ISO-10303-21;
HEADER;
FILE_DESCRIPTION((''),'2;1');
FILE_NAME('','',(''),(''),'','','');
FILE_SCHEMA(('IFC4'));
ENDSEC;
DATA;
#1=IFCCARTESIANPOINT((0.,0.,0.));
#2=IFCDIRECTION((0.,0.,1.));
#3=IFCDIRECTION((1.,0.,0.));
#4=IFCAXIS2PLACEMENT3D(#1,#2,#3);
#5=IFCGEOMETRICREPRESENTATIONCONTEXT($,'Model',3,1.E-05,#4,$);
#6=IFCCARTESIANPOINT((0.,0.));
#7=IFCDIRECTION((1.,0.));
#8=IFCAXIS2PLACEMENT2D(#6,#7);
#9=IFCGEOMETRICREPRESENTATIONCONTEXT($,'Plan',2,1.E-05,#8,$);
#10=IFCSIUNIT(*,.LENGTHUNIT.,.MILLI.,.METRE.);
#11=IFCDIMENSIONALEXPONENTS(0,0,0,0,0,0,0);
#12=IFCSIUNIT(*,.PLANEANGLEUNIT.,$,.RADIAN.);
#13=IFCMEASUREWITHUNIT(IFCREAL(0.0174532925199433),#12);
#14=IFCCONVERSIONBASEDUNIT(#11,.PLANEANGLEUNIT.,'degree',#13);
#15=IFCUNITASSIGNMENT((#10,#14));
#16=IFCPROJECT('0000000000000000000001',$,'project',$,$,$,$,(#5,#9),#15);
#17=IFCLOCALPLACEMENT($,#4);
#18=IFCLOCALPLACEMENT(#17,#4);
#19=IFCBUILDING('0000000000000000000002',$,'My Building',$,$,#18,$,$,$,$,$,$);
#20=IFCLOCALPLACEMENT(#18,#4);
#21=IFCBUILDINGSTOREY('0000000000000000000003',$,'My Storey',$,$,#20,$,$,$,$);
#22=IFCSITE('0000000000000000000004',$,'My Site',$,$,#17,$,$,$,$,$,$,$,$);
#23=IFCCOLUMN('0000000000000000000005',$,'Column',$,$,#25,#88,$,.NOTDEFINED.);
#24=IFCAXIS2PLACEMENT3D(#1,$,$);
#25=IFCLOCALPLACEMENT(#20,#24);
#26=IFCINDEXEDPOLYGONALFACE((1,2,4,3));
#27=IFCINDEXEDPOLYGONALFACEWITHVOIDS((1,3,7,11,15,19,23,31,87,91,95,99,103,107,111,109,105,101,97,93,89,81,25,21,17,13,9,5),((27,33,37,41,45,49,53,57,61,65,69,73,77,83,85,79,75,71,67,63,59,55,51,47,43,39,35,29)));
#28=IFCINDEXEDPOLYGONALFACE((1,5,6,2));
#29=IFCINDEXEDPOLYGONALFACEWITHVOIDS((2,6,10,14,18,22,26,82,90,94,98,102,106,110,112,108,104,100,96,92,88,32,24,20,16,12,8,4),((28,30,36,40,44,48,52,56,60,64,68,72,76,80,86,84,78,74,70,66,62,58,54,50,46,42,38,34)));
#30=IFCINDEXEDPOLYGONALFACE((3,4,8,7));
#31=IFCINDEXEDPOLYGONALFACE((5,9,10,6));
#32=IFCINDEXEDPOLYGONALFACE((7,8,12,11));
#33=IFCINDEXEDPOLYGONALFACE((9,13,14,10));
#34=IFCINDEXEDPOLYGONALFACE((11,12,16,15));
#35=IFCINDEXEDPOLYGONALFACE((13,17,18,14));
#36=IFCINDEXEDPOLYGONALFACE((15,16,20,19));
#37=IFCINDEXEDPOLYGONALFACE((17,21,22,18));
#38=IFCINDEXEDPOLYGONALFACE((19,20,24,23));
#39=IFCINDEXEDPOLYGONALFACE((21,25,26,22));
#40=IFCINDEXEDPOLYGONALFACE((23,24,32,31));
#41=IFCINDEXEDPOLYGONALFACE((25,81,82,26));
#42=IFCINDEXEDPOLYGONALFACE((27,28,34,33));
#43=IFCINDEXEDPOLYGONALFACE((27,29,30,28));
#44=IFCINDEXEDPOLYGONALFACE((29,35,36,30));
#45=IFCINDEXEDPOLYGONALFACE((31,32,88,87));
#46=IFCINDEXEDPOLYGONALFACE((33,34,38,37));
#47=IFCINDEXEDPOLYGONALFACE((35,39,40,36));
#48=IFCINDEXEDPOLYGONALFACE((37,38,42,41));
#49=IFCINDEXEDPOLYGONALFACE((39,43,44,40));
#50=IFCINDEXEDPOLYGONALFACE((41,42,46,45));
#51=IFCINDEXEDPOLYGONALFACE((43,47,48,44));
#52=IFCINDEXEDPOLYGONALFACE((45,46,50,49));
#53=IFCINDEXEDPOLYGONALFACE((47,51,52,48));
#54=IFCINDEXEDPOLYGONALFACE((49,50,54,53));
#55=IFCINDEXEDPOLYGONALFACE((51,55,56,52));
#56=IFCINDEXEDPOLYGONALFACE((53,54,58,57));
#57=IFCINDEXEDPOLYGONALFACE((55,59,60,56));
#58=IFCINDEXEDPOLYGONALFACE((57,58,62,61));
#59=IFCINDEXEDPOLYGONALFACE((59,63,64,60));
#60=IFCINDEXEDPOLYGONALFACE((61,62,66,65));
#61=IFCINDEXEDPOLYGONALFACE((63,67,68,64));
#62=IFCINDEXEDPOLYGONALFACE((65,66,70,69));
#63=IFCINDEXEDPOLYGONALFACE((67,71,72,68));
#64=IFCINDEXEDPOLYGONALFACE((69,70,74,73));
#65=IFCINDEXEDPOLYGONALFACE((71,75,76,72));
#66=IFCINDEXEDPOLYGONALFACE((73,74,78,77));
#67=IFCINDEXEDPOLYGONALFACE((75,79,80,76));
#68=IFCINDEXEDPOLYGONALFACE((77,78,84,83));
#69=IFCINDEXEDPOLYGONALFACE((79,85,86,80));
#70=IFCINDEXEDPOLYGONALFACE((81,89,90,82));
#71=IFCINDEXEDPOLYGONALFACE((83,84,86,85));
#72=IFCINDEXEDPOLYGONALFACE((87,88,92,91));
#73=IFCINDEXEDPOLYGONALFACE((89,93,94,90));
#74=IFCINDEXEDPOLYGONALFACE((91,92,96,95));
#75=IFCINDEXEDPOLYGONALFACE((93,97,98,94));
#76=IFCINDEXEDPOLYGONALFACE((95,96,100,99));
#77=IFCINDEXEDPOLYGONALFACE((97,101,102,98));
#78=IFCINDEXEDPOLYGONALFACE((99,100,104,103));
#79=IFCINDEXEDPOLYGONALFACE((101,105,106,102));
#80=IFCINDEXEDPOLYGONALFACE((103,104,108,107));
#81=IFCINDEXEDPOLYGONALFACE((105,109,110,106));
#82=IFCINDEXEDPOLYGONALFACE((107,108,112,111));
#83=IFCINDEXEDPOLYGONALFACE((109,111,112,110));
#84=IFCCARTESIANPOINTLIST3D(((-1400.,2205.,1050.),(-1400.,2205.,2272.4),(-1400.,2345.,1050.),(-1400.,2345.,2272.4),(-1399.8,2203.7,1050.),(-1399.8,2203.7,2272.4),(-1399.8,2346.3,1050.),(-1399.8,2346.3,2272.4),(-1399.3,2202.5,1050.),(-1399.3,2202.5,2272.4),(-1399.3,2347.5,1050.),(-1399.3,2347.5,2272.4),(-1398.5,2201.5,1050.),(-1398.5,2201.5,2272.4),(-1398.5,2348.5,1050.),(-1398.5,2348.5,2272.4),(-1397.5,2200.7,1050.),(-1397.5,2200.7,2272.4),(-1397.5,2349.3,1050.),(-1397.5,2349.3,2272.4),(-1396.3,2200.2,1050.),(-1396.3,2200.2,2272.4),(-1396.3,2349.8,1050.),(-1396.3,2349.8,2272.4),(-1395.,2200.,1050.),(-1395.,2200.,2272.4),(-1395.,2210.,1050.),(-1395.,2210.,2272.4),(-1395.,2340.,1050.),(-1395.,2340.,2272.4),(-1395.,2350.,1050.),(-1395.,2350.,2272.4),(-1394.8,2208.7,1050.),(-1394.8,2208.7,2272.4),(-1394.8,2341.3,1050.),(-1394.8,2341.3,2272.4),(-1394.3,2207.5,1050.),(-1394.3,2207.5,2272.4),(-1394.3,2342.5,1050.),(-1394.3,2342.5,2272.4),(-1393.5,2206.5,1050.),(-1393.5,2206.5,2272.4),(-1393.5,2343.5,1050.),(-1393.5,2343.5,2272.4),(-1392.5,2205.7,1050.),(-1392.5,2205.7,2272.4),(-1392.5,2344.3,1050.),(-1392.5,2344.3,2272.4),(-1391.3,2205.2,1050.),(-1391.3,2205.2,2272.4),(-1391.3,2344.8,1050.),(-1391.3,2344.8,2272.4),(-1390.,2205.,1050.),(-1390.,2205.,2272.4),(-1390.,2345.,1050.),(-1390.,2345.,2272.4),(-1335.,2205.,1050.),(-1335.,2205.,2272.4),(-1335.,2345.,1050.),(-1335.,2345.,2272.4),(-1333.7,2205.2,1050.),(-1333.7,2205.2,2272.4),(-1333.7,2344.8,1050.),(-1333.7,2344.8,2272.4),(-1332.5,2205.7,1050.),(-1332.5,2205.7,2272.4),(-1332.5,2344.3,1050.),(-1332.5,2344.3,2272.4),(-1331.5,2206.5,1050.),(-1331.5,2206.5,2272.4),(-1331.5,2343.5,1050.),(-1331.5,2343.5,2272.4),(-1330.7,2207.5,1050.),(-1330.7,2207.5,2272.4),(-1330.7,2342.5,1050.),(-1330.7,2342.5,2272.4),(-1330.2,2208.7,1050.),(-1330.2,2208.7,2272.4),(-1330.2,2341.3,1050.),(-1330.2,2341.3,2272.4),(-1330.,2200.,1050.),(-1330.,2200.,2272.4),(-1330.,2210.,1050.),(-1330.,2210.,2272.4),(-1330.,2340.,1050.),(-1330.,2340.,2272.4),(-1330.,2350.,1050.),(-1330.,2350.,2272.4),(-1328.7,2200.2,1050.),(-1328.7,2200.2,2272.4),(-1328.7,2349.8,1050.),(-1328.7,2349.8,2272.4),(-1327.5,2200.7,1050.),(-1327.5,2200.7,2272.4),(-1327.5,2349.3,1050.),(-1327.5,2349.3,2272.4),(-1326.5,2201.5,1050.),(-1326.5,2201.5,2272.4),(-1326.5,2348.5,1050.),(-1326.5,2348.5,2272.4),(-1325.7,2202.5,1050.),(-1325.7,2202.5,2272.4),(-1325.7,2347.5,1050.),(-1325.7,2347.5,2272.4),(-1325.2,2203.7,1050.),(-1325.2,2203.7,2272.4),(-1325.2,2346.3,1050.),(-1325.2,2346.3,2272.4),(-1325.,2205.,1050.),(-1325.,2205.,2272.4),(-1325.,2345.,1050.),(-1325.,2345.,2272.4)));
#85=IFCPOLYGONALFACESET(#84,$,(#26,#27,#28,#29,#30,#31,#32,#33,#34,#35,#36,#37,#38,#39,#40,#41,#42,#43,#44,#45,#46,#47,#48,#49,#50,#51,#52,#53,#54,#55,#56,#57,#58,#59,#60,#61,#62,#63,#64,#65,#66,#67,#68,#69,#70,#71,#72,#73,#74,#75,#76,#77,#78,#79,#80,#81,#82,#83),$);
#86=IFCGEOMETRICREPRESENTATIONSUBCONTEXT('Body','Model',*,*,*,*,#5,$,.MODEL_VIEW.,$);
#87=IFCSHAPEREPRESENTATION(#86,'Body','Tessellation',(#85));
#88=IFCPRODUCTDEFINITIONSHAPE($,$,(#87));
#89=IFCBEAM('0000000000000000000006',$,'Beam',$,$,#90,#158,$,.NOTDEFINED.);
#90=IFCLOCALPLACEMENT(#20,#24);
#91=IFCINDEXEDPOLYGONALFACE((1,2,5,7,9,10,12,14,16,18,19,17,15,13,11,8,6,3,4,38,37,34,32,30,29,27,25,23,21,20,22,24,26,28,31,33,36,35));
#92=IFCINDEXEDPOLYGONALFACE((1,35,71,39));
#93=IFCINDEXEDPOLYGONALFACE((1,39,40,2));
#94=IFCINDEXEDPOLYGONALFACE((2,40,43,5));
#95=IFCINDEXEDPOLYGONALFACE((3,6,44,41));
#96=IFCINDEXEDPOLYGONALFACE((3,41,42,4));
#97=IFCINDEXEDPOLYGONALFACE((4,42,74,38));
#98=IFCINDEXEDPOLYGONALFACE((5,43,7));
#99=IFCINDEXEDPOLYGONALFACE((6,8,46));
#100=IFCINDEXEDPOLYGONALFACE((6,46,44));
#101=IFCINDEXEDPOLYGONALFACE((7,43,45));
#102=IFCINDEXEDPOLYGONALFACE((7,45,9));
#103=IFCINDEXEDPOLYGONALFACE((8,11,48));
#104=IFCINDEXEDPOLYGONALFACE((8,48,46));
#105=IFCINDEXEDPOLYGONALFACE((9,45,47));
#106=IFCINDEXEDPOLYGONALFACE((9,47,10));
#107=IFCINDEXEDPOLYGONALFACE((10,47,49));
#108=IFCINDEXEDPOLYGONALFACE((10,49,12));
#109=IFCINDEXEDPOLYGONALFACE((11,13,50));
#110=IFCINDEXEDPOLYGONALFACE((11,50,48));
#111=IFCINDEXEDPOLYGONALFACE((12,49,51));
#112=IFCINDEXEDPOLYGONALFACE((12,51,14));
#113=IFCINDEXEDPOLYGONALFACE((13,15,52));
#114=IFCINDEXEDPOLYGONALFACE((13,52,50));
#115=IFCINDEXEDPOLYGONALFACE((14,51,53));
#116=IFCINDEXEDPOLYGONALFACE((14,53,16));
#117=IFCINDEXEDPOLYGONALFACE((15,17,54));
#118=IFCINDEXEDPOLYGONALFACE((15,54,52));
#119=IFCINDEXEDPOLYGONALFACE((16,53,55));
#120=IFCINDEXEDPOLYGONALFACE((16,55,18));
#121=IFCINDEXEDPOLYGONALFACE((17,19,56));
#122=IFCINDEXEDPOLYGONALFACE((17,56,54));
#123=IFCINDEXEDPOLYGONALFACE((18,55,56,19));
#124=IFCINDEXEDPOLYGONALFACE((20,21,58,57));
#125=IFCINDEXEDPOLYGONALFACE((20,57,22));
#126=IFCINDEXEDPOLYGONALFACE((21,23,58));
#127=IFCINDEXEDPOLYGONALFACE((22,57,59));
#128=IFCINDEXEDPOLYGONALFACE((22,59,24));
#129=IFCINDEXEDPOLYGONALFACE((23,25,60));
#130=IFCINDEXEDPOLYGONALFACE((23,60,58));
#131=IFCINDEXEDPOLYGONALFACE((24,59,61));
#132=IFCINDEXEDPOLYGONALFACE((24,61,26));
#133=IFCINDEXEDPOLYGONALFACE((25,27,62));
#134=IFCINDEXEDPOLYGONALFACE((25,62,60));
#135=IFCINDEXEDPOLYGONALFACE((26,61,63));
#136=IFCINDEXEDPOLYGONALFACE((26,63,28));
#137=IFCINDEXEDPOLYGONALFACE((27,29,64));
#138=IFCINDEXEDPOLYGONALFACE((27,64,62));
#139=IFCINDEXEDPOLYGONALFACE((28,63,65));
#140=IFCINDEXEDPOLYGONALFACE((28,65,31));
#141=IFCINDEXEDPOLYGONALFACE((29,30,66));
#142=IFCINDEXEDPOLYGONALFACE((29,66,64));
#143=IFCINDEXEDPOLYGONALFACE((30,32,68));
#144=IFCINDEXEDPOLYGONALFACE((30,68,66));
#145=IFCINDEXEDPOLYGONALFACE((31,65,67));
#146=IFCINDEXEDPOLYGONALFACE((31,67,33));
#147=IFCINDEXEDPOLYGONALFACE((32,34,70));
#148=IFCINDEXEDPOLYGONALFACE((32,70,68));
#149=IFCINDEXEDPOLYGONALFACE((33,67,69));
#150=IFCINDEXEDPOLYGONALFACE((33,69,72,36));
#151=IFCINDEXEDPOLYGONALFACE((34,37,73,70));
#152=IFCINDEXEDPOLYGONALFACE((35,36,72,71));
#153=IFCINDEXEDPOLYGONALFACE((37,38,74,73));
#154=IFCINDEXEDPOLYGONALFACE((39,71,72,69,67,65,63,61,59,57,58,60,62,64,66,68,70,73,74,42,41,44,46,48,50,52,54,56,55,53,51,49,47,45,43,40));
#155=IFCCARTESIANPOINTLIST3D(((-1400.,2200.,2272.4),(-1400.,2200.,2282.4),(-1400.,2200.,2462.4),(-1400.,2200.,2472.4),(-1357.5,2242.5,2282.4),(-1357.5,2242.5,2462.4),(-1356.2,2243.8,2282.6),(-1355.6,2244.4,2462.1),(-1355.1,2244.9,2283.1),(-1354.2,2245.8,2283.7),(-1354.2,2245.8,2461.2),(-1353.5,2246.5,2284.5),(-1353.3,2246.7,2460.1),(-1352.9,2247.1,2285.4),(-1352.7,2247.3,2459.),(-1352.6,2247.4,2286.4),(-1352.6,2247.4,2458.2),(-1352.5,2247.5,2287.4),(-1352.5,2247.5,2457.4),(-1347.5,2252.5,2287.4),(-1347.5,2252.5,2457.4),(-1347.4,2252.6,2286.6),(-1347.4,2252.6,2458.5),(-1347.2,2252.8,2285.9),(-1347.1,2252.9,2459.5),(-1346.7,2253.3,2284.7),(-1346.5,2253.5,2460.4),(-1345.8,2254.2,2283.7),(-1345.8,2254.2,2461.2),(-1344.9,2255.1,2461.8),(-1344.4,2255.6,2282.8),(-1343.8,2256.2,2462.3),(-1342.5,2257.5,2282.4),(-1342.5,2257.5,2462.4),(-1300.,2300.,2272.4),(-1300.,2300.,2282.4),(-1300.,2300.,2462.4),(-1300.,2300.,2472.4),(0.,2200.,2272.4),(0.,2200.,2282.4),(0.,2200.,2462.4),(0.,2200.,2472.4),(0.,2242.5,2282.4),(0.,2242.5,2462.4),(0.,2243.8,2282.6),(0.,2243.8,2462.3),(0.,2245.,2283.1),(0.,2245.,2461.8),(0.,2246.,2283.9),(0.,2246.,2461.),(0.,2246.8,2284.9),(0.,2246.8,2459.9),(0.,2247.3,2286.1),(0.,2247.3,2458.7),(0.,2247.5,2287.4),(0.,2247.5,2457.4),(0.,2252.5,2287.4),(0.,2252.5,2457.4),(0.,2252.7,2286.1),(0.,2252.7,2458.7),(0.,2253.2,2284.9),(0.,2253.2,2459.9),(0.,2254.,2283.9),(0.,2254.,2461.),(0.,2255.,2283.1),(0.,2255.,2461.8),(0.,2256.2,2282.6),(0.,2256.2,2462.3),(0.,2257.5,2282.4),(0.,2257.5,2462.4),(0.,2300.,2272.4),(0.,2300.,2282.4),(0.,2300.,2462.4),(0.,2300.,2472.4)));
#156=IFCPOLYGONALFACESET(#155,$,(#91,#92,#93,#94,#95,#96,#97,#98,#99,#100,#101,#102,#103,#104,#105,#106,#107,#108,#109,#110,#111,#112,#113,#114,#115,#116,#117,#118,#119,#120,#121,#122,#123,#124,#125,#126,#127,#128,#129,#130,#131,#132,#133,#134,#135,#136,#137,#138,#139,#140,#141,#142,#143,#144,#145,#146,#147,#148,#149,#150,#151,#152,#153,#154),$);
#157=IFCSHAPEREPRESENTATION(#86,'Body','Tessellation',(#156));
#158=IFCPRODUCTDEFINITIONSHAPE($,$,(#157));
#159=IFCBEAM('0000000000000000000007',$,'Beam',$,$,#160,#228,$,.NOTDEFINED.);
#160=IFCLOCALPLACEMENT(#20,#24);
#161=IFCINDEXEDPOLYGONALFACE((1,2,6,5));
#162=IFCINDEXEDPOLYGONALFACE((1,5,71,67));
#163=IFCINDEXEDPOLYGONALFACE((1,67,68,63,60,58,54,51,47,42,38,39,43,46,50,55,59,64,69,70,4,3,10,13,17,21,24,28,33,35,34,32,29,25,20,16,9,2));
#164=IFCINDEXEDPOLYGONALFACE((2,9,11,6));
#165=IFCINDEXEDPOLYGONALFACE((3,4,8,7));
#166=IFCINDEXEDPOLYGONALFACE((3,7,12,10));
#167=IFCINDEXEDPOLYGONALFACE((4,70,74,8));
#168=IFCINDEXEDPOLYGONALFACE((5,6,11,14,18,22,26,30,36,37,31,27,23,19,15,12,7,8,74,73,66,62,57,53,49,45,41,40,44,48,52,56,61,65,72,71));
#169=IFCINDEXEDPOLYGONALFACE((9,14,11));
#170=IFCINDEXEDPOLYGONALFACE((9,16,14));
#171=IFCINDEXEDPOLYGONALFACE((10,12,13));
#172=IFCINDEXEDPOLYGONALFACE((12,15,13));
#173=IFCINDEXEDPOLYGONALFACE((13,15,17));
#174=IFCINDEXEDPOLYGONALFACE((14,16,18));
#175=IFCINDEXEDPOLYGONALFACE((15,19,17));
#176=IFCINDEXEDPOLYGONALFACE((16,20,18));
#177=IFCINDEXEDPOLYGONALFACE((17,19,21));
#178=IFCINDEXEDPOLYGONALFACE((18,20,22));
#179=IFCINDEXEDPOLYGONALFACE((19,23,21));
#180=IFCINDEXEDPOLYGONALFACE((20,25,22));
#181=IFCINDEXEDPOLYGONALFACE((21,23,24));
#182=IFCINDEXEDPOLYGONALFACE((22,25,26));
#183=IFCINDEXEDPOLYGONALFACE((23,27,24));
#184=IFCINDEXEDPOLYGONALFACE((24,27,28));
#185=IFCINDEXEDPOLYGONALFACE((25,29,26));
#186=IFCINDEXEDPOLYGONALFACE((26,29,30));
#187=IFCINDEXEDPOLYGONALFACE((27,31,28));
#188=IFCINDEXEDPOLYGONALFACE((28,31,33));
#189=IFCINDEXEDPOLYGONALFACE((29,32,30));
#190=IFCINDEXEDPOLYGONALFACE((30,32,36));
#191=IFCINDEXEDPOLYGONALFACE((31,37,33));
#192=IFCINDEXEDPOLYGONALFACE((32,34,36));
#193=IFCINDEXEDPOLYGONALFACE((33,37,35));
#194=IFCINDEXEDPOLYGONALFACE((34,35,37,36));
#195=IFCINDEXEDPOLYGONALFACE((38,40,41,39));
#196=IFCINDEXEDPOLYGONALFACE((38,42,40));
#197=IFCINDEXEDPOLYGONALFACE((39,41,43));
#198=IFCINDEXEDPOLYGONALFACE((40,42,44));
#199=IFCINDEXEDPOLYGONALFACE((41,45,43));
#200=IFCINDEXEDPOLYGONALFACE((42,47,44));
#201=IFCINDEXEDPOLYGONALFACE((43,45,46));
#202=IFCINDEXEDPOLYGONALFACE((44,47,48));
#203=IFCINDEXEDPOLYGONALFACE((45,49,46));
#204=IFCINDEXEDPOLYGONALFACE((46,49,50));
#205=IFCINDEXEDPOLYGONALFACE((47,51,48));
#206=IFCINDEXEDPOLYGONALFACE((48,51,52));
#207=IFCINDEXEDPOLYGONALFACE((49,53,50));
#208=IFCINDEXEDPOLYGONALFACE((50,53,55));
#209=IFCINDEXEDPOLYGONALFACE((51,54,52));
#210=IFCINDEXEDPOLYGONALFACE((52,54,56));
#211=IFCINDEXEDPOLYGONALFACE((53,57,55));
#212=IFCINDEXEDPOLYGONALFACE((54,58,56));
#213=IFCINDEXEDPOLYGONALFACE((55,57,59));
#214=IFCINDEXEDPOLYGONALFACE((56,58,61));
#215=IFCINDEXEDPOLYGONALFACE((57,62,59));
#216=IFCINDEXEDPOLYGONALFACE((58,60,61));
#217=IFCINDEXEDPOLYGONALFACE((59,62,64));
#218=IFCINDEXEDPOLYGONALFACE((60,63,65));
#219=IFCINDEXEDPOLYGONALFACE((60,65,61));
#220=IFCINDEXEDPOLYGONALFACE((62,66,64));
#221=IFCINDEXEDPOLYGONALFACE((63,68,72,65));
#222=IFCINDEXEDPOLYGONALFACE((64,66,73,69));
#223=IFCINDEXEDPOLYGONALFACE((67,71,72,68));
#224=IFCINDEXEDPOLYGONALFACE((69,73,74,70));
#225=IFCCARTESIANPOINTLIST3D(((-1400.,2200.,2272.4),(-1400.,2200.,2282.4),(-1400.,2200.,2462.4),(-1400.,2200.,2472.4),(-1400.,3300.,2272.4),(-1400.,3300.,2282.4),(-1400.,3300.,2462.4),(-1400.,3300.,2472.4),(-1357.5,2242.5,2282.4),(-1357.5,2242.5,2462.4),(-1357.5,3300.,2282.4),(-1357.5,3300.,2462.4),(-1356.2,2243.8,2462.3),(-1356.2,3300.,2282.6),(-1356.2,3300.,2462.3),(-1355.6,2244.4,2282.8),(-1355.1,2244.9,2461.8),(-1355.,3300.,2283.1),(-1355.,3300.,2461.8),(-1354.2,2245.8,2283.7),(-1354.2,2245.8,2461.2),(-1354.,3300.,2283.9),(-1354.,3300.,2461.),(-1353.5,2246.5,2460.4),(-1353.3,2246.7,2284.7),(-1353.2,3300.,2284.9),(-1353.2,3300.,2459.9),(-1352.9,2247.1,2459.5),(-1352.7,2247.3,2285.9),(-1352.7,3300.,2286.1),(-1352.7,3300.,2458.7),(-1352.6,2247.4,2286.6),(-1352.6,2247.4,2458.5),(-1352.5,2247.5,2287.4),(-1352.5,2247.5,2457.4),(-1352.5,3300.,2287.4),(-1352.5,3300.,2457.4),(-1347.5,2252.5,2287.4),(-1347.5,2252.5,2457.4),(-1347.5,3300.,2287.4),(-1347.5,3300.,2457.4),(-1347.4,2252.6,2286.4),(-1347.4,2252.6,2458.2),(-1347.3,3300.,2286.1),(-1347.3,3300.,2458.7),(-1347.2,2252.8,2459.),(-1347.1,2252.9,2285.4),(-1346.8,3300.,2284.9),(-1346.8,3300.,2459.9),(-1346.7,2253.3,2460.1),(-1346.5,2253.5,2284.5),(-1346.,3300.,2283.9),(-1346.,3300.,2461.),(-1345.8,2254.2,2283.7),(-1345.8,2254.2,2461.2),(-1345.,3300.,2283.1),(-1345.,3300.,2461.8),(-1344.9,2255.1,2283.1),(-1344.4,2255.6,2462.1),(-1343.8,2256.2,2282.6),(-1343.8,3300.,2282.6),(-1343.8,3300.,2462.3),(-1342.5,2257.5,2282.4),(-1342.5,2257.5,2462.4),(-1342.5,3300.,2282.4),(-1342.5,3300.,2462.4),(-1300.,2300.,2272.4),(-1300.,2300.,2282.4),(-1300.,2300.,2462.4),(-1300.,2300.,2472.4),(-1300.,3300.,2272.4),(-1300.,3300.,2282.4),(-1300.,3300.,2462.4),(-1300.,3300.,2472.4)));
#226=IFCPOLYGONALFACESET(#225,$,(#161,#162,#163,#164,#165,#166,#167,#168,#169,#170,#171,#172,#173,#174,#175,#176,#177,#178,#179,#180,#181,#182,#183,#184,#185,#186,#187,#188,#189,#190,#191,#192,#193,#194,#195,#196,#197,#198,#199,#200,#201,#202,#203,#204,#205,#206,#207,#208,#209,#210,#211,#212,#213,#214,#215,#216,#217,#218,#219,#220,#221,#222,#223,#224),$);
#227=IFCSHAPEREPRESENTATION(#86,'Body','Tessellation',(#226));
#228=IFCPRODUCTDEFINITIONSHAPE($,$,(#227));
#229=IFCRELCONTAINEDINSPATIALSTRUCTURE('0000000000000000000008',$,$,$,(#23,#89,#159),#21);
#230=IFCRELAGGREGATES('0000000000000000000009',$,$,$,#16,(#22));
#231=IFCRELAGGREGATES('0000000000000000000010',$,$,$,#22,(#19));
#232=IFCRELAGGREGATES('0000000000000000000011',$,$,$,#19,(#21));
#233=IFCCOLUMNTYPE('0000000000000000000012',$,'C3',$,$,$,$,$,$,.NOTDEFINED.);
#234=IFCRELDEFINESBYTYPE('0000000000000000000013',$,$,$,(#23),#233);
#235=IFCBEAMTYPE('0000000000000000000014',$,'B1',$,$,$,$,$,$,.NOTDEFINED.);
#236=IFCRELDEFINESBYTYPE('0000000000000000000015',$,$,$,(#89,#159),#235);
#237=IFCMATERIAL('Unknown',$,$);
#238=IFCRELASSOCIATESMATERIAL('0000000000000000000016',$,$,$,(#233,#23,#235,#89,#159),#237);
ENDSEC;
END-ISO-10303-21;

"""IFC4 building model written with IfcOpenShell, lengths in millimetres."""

from ifc_helpers import new_model, entity, si_unit, converted_unit, frame, origin_with_axes, origin_2d_with_axis, place, context, subcontext, project, spatial, hollow_rectangle, i_section, extrude, clip, halfspace, material, material_profile, profile_set, profile_usage, type_object, element, save


model = new_model("IFC4")

# Units and contexts
model_context = context("Model", 3, precision=1e-05, world=origin_with_axes())
plan_context = context("Plan", 2, precision=1e-05, world=origin_2d_with_axis())
body_context = subcontext(model_context, "Body", "Model", "MODEL_VIEW")
ifc_project = project(units=[si_unit("LENGTHUNIT", "METRE", prefix="MILLI"), converted_unit("PLANEANGLEUNIT", "degree", entity("IfcReal", 0.0174532925199433), si_unit("PLANEANGLEUNIT", "RADIAN"), dimensions=[0, 0, 0, 0, 0, 0, 0])], contexts=[model_context, plan_context])

# Site, building, storey
site_placement = place(None, origin_with_axes())
site = spatial("IfcSite", under=ifc_project, at=site_placement, Name="My Site")
building_placement = place(site_placement, origin_with_axes())
building = spatial("IfcBuilding", under=site, at=building_placement, Name="My Building")
storey_placement = place(building_placement, origin_with_axes())
storey = spatial("IfcBuildingStorey", under=building, at=storey_placement, Name="My Storey")

# Column
ifc_material = material(Name="Unknown")
ifc_material_profile_1 = material_profile(ifc_material, hollow_rectangle(XDim=75.0, YDim=150.0, WallThickness=5.0, InnerFilletRadius=5.0, OuterFilletRadius=5.0))
ifc_profile_set_1 = profile_set([ifc_material_profile_1])
ifc_profile_usage_1 = profile_usage(ifc_profile_set_1, cardinal=5)
column_type = type_object("IfcColumnType", Name="C3", PredefinedType="NOTDEFINED", material=ifc_profile_set_1)
column_placement = place(storey_placement, frame((-1362.5, 2275.0, 1050.0), z_axis=(0.0, 0.0, 1.0), x_axis=(1.0, 0.0, 0.0)))
element("IfcColumn", 1, at=column_placement, inside=storey, type_object=column_type, material=ifc_profile_usage_1, Name="Column", PredefinedType="NOTDEFINED", context=body_context, shape_type="SweptSolid", body=[
    extrude(hollow_rectangle(XDim=75.0, YDim=150.0, WallThickness=5.0, InnerFilletRadius=5.0, OuterFilletRadius=5.0), origin_with_axes(), (0.0, 0.0, 1.0), 1222.4),
])

# Beams
ifc_material_profile_2 = material_profile(ifc_material, i_section(OverallWidth=100.0, OverallDepth=200.0, WebThickness=5.0, FlangeThickness=10.0, FilletRadius=5.0))
ifc_profile_set_2 = profile_set([ifc_material_profile_2])
ifc_profile_usage_2 = profile_usage(ifc_profile_set_2, cardinal=5)
beam_type_1 = type_object("IfcBeamType", Name="B1", PredefinedType="NOTDEFINED", material=ifc_profile_set_2)
beam_1_placement = place(storey_placement, frame((-1400.0, 2250.0, 2372.4), z_axis=(1.0, 0.0, 0.0), x_axis=(0.0, 1.0, 0.0)))
element("IfcBeam", 2, at=beam_1_placement, inside=storey, type_object=beam_type_1, material=ifc_profile_usage_2, Name="Beam", PredefinedType="NOTDEFINED", context=body_context, shape_type="Clipping", body=[
    clip(extrude(i_section(OverallWidth=100.0, OverallDepth=200.0, WebThickness=5.0, FlangeThickness=10.0, FilletRadius=5.0), origin_with_axes(), (0.0, 0.0, 1.0), 1400.0), halfspace(frame((-50.0, -2372.4, 0.0), z_axis=(0.707107, 0.0, -0.707107), x_axis=(0.707107, 0.0, 0.707107)), False)),
])
ifc_profile_usage_3 = profile_usage(ifc_profile_set_2, cardinal=5)
beam_2_placement = place(storey_placement, frame((-1350.0, 2200.0, 2372.4), z_axis=(0.0, 1.0, 0.0), x_axis=(-1.0, 0.0, 0.0)))
element("IfcBeam", 3, at=beam_2_placement, inside=storey, type_object=beam_type_1, material=ifc_profile_usage_3, Name="Beam", PredefinedType="NOTDEFINED", context=body_context, shape_type="Clipping", body=[
    clip(extrude(i_section(OverallWidth=100.0, OverallDepth=200.0, WebThickness=5.0, FlangeThickness=10.0, FilletRadius=5.0), origin_with_axes(), (0.0, 0.0, 1.0), 1100.0), halfspace(frame((50.0, -2372.4, 0.0), z_axis=(-0.707107, 0.0, -0.707107), x_axis=(-0.707107, 0.0, 0.707107)), False)),
])

save(model, "model.ifc")
